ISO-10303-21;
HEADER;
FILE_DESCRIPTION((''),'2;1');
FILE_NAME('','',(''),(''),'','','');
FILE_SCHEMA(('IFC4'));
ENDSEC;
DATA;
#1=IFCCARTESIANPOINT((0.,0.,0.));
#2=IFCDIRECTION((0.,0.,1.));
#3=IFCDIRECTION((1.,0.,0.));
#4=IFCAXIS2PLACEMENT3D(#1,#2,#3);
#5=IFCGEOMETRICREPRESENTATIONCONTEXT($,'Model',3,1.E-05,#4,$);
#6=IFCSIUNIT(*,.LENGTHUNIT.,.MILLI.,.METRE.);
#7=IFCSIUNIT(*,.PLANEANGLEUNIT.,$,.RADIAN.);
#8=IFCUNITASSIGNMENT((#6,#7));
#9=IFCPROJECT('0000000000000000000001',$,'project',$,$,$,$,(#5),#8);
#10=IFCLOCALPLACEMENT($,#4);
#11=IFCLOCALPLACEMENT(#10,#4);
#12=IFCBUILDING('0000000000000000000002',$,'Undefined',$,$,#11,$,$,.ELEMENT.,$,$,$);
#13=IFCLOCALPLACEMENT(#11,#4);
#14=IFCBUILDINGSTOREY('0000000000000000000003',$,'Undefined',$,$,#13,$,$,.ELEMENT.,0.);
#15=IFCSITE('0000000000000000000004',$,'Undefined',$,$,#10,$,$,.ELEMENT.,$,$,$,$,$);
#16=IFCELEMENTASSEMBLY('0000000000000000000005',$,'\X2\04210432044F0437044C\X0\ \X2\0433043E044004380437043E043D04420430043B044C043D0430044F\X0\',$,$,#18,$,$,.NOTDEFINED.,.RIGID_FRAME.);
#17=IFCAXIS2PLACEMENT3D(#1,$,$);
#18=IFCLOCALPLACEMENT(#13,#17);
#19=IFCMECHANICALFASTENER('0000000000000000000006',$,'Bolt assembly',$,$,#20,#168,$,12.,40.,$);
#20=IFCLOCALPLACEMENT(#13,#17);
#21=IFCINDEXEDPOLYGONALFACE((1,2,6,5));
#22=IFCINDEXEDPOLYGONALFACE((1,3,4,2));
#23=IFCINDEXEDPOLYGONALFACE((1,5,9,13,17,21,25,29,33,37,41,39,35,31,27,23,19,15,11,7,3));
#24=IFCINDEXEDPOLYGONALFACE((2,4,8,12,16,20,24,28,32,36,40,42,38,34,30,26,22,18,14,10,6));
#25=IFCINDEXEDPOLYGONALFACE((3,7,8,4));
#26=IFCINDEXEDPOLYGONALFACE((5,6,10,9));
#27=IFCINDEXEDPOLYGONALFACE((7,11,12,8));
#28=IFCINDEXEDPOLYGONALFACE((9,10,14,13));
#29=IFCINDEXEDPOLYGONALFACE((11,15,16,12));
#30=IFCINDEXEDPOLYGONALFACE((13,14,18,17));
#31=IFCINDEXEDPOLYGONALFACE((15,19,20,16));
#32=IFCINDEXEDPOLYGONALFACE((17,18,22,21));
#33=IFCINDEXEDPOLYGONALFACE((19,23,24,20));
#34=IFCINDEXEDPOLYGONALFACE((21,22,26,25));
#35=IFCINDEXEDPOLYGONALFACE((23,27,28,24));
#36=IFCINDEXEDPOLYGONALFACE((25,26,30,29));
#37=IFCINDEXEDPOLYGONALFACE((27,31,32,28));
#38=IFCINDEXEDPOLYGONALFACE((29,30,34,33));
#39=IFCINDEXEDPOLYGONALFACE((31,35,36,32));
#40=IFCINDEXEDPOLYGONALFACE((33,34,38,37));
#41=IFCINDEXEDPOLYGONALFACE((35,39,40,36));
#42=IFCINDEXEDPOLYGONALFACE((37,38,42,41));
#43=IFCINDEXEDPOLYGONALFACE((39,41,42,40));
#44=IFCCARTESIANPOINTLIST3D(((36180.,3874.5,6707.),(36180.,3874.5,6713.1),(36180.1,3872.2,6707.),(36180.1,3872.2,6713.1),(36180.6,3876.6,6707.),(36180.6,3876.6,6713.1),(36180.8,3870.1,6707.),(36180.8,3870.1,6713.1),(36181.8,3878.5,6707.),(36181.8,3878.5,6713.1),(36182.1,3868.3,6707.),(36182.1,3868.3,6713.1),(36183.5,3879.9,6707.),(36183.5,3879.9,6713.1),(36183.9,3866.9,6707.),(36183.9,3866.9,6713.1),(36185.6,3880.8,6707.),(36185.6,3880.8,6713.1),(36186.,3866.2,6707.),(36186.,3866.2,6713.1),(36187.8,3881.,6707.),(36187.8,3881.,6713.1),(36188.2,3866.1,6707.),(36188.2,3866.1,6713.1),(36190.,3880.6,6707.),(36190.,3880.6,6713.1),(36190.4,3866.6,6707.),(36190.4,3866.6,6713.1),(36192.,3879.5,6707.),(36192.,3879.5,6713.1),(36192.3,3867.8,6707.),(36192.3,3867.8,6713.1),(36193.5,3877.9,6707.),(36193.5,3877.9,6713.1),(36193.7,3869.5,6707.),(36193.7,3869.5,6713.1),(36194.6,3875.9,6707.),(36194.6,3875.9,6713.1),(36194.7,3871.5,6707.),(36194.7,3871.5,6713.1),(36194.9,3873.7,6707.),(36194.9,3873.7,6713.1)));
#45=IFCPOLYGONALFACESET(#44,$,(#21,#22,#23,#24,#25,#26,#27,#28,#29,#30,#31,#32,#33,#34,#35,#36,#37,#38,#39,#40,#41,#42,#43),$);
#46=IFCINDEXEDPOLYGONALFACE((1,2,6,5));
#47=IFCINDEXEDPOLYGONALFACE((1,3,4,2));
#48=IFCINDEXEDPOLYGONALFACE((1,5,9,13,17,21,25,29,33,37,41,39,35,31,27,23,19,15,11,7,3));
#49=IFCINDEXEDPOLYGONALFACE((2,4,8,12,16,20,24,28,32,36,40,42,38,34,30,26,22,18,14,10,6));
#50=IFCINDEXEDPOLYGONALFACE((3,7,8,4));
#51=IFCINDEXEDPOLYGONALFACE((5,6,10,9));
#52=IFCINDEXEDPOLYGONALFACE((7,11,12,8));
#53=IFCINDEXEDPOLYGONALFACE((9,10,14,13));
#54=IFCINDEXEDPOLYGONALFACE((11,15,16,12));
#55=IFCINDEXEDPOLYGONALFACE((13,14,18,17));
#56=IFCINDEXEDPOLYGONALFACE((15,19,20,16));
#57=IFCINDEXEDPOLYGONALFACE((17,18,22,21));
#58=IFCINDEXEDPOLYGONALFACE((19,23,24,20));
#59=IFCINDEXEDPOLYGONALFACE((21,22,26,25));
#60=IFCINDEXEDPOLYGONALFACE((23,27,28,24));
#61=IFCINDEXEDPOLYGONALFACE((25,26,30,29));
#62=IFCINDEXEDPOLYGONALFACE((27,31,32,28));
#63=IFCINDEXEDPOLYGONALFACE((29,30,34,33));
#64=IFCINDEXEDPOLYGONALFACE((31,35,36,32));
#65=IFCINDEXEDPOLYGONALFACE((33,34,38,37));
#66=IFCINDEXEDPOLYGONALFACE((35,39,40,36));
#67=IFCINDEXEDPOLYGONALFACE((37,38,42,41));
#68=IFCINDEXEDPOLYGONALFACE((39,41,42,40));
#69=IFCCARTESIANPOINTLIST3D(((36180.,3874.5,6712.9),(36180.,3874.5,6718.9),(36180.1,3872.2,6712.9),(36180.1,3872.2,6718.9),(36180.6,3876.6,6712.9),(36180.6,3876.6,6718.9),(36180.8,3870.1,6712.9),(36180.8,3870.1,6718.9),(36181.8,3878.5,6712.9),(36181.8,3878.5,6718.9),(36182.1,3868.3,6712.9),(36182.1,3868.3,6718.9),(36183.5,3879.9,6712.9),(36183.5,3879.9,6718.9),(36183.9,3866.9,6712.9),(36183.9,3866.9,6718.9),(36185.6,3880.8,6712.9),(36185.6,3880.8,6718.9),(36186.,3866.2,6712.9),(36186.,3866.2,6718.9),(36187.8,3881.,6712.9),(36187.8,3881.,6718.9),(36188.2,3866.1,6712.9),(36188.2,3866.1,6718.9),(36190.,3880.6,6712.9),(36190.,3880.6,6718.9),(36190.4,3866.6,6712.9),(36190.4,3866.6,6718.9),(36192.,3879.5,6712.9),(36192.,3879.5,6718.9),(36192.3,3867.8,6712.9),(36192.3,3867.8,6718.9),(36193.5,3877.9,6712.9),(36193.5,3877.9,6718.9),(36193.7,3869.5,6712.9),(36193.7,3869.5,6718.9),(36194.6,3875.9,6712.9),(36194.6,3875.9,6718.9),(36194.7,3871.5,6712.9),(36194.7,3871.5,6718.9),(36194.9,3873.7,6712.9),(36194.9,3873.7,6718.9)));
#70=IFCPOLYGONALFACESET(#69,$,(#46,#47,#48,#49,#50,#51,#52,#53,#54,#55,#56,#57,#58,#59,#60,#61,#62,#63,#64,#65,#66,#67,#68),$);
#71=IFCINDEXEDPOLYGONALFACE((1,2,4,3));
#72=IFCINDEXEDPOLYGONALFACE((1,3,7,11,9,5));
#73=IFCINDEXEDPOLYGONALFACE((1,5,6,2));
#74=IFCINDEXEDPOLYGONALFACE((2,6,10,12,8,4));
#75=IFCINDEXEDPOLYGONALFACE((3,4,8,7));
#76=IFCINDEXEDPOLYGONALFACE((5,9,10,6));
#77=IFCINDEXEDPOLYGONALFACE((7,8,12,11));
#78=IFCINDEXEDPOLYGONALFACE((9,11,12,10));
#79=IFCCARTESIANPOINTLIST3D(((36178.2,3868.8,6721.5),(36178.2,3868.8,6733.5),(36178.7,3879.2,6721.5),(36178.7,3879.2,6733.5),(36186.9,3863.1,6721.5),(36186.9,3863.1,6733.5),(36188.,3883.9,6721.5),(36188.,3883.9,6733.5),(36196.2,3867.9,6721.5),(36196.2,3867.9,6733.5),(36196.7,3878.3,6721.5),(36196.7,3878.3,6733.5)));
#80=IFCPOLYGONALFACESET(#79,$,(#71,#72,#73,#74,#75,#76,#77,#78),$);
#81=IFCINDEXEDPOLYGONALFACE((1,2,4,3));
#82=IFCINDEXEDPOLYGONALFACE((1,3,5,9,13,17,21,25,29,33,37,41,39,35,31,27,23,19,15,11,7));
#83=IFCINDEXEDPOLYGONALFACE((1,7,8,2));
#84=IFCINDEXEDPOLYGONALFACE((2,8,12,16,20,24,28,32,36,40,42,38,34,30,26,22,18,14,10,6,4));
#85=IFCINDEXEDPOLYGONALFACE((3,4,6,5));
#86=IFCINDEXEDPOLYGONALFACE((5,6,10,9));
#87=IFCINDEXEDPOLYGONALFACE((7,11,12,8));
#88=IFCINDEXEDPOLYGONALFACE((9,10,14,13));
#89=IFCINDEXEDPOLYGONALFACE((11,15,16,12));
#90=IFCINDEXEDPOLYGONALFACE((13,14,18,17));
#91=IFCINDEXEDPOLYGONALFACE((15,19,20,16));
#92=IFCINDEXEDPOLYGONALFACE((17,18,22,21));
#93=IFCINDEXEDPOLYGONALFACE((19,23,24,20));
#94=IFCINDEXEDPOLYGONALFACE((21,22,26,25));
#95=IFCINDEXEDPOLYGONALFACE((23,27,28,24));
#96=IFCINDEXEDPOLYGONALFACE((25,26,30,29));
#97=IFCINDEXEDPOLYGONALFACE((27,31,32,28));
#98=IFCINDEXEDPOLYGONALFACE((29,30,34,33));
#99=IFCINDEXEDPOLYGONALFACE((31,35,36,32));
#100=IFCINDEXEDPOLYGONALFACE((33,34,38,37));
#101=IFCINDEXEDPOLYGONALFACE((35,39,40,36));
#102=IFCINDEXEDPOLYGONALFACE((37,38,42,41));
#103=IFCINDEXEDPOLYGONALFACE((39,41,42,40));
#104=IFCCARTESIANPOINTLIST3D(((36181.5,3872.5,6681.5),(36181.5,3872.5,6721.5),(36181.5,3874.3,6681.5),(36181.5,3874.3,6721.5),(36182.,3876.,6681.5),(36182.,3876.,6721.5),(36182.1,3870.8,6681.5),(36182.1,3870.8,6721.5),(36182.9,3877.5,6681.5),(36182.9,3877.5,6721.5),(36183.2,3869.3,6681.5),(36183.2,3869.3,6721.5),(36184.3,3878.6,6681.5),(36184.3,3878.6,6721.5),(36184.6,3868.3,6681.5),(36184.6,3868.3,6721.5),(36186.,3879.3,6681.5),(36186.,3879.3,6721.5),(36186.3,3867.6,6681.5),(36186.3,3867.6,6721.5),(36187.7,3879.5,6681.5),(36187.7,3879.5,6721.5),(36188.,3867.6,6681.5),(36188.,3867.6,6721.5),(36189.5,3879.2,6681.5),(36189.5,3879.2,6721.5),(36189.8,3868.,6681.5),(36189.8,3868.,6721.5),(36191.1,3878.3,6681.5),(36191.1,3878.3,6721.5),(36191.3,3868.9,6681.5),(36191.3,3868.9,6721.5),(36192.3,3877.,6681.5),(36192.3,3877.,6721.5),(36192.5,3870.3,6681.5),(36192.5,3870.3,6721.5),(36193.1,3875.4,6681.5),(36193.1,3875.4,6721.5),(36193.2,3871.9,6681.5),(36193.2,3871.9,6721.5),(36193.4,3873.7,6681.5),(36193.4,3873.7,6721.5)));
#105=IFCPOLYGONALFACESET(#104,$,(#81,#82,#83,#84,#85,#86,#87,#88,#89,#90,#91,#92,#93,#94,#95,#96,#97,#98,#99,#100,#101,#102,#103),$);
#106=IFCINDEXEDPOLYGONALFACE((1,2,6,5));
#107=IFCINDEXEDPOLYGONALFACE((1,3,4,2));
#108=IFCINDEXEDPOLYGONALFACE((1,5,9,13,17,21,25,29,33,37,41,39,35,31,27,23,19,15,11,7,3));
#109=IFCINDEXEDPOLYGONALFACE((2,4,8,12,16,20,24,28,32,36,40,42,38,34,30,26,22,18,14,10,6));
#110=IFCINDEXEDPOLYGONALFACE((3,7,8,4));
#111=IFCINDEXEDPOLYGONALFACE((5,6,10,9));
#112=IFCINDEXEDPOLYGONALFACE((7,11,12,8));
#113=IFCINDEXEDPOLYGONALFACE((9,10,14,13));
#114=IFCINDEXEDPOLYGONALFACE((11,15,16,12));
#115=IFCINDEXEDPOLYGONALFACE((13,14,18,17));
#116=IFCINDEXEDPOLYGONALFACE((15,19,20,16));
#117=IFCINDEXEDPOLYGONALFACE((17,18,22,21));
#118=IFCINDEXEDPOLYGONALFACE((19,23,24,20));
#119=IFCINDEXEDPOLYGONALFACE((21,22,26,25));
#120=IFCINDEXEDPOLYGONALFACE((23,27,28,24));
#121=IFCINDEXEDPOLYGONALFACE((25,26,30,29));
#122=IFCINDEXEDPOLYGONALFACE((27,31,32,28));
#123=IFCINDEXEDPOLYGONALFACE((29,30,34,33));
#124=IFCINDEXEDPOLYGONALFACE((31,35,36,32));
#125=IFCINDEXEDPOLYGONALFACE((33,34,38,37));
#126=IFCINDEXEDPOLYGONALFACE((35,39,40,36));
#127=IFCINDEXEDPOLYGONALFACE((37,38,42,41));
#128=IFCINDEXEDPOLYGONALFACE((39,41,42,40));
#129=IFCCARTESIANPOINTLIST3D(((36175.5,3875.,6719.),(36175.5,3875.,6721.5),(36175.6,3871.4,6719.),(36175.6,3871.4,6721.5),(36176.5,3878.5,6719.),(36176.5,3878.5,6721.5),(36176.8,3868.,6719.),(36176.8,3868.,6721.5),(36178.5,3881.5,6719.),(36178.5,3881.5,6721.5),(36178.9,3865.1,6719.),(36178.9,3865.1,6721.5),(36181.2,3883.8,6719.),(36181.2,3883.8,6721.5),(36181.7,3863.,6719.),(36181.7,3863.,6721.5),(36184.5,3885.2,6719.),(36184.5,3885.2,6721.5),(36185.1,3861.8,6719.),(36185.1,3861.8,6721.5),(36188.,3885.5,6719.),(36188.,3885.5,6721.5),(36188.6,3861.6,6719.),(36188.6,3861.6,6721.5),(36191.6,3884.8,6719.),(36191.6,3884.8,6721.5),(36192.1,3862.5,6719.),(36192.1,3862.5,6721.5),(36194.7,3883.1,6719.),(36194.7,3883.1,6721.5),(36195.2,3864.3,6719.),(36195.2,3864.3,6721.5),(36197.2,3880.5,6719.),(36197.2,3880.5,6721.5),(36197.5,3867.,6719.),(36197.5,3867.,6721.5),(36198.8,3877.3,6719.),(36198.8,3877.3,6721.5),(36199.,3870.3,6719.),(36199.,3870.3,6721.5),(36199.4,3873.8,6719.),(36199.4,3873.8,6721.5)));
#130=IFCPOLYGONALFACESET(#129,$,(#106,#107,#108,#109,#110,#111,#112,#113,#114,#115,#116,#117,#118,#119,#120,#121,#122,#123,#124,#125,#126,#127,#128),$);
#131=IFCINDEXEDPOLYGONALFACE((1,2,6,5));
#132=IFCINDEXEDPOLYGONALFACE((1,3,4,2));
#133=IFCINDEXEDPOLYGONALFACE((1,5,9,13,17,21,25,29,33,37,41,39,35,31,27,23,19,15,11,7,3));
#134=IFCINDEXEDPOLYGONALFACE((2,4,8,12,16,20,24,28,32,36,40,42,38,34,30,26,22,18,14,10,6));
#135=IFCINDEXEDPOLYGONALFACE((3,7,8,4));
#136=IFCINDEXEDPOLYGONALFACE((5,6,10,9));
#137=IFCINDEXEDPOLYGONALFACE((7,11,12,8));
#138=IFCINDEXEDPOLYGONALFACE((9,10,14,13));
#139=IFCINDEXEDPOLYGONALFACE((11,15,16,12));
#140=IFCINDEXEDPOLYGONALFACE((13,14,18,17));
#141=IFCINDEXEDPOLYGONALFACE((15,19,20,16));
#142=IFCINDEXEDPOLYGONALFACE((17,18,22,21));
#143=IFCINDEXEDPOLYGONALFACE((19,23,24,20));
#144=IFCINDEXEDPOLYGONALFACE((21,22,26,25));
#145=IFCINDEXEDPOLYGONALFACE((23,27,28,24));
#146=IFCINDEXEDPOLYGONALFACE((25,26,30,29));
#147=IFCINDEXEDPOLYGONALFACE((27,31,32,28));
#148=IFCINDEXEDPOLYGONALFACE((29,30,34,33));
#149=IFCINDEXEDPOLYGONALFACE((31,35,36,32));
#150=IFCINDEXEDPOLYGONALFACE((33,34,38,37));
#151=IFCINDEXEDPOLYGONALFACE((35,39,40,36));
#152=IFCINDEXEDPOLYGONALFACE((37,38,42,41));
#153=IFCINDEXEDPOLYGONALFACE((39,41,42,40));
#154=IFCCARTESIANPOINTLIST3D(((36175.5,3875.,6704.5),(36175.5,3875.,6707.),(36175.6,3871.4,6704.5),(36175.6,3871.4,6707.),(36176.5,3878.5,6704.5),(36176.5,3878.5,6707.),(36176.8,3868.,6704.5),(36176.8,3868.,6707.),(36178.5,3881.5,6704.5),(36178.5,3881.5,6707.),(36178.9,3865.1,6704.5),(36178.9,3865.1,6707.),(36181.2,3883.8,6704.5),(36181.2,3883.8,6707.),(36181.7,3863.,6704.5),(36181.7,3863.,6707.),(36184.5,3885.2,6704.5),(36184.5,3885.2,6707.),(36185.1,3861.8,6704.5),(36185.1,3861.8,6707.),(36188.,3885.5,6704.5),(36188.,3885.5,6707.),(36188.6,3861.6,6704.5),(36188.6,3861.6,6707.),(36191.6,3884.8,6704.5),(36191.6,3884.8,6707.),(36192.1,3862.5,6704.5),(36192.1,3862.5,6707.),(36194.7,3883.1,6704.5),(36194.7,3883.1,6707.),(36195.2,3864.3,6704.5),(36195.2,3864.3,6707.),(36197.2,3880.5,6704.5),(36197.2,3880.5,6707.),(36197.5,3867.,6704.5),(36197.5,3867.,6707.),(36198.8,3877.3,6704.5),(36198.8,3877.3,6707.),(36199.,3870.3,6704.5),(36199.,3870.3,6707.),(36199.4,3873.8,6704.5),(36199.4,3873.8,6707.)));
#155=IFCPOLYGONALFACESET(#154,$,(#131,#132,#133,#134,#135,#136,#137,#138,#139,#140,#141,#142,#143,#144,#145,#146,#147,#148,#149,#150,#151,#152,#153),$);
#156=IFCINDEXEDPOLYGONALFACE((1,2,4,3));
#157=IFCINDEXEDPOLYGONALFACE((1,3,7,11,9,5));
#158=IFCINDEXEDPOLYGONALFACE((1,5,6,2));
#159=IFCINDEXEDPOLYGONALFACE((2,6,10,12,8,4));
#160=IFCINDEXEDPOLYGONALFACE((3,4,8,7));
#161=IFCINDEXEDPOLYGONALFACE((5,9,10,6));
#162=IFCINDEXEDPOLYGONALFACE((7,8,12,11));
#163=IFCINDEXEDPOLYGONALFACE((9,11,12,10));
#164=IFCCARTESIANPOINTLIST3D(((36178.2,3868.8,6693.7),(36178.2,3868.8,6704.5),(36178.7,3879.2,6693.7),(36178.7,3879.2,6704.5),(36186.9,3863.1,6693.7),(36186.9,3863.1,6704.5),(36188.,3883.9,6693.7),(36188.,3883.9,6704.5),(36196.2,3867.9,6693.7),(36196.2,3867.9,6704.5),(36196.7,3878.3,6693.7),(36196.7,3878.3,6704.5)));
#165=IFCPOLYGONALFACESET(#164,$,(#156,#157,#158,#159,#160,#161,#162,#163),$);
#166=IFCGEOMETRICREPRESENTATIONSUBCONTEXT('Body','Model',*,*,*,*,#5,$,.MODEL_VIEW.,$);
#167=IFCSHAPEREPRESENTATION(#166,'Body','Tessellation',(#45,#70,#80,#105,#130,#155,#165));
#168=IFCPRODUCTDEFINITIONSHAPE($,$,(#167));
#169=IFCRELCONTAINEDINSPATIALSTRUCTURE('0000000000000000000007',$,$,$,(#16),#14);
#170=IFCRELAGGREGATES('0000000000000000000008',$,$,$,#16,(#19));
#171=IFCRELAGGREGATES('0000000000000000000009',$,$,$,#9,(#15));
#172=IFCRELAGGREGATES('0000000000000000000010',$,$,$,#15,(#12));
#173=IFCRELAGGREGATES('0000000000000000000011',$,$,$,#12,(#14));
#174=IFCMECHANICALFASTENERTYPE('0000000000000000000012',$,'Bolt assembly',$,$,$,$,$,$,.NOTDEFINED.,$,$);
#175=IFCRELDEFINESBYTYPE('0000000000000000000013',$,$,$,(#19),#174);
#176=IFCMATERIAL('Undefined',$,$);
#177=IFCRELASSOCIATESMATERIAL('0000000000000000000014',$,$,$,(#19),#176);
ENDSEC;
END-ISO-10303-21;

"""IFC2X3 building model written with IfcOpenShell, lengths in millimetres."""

from ifc_helpers import new_model, si_unit, frame, origin_with_axes, origin_2d_with_axis, place, context, subcontext, project, spatial, polyline, circle, outline, extrude, source, transform, mapped, material, type_object, element, aggregate, save


model = new_model("IFC2X3")

# Units and contexts
model_context = context("Model", 3, precision=1e-05, world=origin_with_axes())
body_context = subcontext(model_context, "Body", "Model", "MODEL_VIEW")
ifc_project = project(units=[si_unit("LENGTHUNIT", "METRE", prefix="MILLI"), si_unit("PLANEANGLEUNIT", "RADIAN")], contexts=[model_context])

# Site, building, storey
site_placement = place(None, origin_with_axes())
site = spatial("IfcSite", under=ifc_project, at=site_placement, Name="Undefined", CompositionType="ELEMENT")
building_placement = place(site_placement, origin_with_axes())
building = spatial("IfcBuilding", under=site, at=building_placement, Name="Undefined", CompositionType="ELEMENT")
storey_placement = place(building_placement, origin_with_axes())
storey = spatial("IfcBuildingStorey", under=building, at=storey_placement, Name="Undefined", CompositionType="ELEMENT", Elevation=0.0)

# Element assembly
assembly_1_placement = place(storey_placement, origin_with_axes())
assembly_1 = element("IfcElementAssembly", 1, at=assembly_1_placement, inside=storey, Name="Связь горизонтальная", AssemblyPlace="NOTDEFINED", PredefinedType="RIGID_FRAME")

# Mechanical fastener
ifc_material_1 = material(Name="Undefined")
mechanical_fastener_type = type_object("IfcMechanicalFastenerType", Name="Bolt assembly")
shared_shape_1 = source(origin_with_axes(), body_context, "Body", "SweptSolid", [
    extrude(circle(Radius=7.5, at=origin_2d_with_axis()), frame((0.0, -0.1, 0.0), z_axis=(0.0, 1.0, 0.0), x_axis=(1.0, 0.0, 0.0)), (0.0, 0.0, 1.0), 6.1),
    extrude(circle(Radius=7.5, at=origin_2d_with_axis()), frame((0.0, -5.9, 0.0), z_axis=(0.0, 1.0, 0.0), x_axis=(1.0, 0.0, 0.0)), (0.0, 0.0, 1.0), 6.0),
    extrude(outline(polyline([(10.4, 0.0), (5.2, 9.0), (-5.2, 9.0), (-10.4, 0.0), (-5.2, -9.0), (5.2, -9.0), (10.4, 0.0)])), frame((0.0, -20.5, 0.0), z_axis=(0.0, 1.0, 0.0), x_axis=(1.0, 0.0, 0.0)), (0.0, 0.0, 1.0), 12.0),
    extrude(circle(Radius=6.0, at=origin_2d_with_axis()), frame((0.0, -8.5, 0.0), z_axis=(0.0, 1.0, 0.0), x_axis=(1.0, 0.0, 0.0)), (0.0, 0.0, 1.0), 40.0),
    extrude(circle(Radius=12.0, at=origin_2d_with_axis()), frame((0.0, -8.5, 0.0), z_axis=(0.0, 1.0, 0.0), x_axis=(1.0, 0.0, 0.0)), (0.0, 0.0, 1.0), 2.5),
    extrude(circle(Radius=12.0, at=origin_2d_with_axis()), frame((0.0, 6.0, 0.0), z_axis=(0.0, 1.0, 0.0), x_axis=(1.0, 0.0, 0.0)), (0.0, 0.0, 1.0), 2.5),
    extrude(outline(polyline([(10.4, 0.0), (5.2, 9.0), (-5.2, 9.0), (-10.4, 0.0), (-5.2, -9.0), (5.2, -9.0), (10.4, 0.0)])), frame((0.0, 8.5, 0.0), z_axis=(0.0, 1.0, 0.0), x_axis=(1.0, 0.0, 0.0)), (0.0, 0.0, 1.0), 10.8),
])
mechanical_fastener_1_placement = place(assembly_1_placement, frame((36187.4, 3873.5, 6713.0), z_axis=(0.542525, 0.840039, 0.0), x_axis=(0.840039, -0.542525, 0.0)))
mechanical_fastener_1 = element("IfcMechanicalFastener", 2, at=mechanical_fastener_1_placement, type_object=mechanical_fastener_type, material=ifc_material_1, Name="Bolt assembly", NominalDiameter=12.0, NominalLength=40.0, context=body_context, shape_type="MappedRepresentation", body=[
    mapped(shared_shape_1, transform((0.0, 0.0, 0.0))),
])
aggregate(assembly_1, [mechanical_fastener_1])

save(model, "model.ifc")
